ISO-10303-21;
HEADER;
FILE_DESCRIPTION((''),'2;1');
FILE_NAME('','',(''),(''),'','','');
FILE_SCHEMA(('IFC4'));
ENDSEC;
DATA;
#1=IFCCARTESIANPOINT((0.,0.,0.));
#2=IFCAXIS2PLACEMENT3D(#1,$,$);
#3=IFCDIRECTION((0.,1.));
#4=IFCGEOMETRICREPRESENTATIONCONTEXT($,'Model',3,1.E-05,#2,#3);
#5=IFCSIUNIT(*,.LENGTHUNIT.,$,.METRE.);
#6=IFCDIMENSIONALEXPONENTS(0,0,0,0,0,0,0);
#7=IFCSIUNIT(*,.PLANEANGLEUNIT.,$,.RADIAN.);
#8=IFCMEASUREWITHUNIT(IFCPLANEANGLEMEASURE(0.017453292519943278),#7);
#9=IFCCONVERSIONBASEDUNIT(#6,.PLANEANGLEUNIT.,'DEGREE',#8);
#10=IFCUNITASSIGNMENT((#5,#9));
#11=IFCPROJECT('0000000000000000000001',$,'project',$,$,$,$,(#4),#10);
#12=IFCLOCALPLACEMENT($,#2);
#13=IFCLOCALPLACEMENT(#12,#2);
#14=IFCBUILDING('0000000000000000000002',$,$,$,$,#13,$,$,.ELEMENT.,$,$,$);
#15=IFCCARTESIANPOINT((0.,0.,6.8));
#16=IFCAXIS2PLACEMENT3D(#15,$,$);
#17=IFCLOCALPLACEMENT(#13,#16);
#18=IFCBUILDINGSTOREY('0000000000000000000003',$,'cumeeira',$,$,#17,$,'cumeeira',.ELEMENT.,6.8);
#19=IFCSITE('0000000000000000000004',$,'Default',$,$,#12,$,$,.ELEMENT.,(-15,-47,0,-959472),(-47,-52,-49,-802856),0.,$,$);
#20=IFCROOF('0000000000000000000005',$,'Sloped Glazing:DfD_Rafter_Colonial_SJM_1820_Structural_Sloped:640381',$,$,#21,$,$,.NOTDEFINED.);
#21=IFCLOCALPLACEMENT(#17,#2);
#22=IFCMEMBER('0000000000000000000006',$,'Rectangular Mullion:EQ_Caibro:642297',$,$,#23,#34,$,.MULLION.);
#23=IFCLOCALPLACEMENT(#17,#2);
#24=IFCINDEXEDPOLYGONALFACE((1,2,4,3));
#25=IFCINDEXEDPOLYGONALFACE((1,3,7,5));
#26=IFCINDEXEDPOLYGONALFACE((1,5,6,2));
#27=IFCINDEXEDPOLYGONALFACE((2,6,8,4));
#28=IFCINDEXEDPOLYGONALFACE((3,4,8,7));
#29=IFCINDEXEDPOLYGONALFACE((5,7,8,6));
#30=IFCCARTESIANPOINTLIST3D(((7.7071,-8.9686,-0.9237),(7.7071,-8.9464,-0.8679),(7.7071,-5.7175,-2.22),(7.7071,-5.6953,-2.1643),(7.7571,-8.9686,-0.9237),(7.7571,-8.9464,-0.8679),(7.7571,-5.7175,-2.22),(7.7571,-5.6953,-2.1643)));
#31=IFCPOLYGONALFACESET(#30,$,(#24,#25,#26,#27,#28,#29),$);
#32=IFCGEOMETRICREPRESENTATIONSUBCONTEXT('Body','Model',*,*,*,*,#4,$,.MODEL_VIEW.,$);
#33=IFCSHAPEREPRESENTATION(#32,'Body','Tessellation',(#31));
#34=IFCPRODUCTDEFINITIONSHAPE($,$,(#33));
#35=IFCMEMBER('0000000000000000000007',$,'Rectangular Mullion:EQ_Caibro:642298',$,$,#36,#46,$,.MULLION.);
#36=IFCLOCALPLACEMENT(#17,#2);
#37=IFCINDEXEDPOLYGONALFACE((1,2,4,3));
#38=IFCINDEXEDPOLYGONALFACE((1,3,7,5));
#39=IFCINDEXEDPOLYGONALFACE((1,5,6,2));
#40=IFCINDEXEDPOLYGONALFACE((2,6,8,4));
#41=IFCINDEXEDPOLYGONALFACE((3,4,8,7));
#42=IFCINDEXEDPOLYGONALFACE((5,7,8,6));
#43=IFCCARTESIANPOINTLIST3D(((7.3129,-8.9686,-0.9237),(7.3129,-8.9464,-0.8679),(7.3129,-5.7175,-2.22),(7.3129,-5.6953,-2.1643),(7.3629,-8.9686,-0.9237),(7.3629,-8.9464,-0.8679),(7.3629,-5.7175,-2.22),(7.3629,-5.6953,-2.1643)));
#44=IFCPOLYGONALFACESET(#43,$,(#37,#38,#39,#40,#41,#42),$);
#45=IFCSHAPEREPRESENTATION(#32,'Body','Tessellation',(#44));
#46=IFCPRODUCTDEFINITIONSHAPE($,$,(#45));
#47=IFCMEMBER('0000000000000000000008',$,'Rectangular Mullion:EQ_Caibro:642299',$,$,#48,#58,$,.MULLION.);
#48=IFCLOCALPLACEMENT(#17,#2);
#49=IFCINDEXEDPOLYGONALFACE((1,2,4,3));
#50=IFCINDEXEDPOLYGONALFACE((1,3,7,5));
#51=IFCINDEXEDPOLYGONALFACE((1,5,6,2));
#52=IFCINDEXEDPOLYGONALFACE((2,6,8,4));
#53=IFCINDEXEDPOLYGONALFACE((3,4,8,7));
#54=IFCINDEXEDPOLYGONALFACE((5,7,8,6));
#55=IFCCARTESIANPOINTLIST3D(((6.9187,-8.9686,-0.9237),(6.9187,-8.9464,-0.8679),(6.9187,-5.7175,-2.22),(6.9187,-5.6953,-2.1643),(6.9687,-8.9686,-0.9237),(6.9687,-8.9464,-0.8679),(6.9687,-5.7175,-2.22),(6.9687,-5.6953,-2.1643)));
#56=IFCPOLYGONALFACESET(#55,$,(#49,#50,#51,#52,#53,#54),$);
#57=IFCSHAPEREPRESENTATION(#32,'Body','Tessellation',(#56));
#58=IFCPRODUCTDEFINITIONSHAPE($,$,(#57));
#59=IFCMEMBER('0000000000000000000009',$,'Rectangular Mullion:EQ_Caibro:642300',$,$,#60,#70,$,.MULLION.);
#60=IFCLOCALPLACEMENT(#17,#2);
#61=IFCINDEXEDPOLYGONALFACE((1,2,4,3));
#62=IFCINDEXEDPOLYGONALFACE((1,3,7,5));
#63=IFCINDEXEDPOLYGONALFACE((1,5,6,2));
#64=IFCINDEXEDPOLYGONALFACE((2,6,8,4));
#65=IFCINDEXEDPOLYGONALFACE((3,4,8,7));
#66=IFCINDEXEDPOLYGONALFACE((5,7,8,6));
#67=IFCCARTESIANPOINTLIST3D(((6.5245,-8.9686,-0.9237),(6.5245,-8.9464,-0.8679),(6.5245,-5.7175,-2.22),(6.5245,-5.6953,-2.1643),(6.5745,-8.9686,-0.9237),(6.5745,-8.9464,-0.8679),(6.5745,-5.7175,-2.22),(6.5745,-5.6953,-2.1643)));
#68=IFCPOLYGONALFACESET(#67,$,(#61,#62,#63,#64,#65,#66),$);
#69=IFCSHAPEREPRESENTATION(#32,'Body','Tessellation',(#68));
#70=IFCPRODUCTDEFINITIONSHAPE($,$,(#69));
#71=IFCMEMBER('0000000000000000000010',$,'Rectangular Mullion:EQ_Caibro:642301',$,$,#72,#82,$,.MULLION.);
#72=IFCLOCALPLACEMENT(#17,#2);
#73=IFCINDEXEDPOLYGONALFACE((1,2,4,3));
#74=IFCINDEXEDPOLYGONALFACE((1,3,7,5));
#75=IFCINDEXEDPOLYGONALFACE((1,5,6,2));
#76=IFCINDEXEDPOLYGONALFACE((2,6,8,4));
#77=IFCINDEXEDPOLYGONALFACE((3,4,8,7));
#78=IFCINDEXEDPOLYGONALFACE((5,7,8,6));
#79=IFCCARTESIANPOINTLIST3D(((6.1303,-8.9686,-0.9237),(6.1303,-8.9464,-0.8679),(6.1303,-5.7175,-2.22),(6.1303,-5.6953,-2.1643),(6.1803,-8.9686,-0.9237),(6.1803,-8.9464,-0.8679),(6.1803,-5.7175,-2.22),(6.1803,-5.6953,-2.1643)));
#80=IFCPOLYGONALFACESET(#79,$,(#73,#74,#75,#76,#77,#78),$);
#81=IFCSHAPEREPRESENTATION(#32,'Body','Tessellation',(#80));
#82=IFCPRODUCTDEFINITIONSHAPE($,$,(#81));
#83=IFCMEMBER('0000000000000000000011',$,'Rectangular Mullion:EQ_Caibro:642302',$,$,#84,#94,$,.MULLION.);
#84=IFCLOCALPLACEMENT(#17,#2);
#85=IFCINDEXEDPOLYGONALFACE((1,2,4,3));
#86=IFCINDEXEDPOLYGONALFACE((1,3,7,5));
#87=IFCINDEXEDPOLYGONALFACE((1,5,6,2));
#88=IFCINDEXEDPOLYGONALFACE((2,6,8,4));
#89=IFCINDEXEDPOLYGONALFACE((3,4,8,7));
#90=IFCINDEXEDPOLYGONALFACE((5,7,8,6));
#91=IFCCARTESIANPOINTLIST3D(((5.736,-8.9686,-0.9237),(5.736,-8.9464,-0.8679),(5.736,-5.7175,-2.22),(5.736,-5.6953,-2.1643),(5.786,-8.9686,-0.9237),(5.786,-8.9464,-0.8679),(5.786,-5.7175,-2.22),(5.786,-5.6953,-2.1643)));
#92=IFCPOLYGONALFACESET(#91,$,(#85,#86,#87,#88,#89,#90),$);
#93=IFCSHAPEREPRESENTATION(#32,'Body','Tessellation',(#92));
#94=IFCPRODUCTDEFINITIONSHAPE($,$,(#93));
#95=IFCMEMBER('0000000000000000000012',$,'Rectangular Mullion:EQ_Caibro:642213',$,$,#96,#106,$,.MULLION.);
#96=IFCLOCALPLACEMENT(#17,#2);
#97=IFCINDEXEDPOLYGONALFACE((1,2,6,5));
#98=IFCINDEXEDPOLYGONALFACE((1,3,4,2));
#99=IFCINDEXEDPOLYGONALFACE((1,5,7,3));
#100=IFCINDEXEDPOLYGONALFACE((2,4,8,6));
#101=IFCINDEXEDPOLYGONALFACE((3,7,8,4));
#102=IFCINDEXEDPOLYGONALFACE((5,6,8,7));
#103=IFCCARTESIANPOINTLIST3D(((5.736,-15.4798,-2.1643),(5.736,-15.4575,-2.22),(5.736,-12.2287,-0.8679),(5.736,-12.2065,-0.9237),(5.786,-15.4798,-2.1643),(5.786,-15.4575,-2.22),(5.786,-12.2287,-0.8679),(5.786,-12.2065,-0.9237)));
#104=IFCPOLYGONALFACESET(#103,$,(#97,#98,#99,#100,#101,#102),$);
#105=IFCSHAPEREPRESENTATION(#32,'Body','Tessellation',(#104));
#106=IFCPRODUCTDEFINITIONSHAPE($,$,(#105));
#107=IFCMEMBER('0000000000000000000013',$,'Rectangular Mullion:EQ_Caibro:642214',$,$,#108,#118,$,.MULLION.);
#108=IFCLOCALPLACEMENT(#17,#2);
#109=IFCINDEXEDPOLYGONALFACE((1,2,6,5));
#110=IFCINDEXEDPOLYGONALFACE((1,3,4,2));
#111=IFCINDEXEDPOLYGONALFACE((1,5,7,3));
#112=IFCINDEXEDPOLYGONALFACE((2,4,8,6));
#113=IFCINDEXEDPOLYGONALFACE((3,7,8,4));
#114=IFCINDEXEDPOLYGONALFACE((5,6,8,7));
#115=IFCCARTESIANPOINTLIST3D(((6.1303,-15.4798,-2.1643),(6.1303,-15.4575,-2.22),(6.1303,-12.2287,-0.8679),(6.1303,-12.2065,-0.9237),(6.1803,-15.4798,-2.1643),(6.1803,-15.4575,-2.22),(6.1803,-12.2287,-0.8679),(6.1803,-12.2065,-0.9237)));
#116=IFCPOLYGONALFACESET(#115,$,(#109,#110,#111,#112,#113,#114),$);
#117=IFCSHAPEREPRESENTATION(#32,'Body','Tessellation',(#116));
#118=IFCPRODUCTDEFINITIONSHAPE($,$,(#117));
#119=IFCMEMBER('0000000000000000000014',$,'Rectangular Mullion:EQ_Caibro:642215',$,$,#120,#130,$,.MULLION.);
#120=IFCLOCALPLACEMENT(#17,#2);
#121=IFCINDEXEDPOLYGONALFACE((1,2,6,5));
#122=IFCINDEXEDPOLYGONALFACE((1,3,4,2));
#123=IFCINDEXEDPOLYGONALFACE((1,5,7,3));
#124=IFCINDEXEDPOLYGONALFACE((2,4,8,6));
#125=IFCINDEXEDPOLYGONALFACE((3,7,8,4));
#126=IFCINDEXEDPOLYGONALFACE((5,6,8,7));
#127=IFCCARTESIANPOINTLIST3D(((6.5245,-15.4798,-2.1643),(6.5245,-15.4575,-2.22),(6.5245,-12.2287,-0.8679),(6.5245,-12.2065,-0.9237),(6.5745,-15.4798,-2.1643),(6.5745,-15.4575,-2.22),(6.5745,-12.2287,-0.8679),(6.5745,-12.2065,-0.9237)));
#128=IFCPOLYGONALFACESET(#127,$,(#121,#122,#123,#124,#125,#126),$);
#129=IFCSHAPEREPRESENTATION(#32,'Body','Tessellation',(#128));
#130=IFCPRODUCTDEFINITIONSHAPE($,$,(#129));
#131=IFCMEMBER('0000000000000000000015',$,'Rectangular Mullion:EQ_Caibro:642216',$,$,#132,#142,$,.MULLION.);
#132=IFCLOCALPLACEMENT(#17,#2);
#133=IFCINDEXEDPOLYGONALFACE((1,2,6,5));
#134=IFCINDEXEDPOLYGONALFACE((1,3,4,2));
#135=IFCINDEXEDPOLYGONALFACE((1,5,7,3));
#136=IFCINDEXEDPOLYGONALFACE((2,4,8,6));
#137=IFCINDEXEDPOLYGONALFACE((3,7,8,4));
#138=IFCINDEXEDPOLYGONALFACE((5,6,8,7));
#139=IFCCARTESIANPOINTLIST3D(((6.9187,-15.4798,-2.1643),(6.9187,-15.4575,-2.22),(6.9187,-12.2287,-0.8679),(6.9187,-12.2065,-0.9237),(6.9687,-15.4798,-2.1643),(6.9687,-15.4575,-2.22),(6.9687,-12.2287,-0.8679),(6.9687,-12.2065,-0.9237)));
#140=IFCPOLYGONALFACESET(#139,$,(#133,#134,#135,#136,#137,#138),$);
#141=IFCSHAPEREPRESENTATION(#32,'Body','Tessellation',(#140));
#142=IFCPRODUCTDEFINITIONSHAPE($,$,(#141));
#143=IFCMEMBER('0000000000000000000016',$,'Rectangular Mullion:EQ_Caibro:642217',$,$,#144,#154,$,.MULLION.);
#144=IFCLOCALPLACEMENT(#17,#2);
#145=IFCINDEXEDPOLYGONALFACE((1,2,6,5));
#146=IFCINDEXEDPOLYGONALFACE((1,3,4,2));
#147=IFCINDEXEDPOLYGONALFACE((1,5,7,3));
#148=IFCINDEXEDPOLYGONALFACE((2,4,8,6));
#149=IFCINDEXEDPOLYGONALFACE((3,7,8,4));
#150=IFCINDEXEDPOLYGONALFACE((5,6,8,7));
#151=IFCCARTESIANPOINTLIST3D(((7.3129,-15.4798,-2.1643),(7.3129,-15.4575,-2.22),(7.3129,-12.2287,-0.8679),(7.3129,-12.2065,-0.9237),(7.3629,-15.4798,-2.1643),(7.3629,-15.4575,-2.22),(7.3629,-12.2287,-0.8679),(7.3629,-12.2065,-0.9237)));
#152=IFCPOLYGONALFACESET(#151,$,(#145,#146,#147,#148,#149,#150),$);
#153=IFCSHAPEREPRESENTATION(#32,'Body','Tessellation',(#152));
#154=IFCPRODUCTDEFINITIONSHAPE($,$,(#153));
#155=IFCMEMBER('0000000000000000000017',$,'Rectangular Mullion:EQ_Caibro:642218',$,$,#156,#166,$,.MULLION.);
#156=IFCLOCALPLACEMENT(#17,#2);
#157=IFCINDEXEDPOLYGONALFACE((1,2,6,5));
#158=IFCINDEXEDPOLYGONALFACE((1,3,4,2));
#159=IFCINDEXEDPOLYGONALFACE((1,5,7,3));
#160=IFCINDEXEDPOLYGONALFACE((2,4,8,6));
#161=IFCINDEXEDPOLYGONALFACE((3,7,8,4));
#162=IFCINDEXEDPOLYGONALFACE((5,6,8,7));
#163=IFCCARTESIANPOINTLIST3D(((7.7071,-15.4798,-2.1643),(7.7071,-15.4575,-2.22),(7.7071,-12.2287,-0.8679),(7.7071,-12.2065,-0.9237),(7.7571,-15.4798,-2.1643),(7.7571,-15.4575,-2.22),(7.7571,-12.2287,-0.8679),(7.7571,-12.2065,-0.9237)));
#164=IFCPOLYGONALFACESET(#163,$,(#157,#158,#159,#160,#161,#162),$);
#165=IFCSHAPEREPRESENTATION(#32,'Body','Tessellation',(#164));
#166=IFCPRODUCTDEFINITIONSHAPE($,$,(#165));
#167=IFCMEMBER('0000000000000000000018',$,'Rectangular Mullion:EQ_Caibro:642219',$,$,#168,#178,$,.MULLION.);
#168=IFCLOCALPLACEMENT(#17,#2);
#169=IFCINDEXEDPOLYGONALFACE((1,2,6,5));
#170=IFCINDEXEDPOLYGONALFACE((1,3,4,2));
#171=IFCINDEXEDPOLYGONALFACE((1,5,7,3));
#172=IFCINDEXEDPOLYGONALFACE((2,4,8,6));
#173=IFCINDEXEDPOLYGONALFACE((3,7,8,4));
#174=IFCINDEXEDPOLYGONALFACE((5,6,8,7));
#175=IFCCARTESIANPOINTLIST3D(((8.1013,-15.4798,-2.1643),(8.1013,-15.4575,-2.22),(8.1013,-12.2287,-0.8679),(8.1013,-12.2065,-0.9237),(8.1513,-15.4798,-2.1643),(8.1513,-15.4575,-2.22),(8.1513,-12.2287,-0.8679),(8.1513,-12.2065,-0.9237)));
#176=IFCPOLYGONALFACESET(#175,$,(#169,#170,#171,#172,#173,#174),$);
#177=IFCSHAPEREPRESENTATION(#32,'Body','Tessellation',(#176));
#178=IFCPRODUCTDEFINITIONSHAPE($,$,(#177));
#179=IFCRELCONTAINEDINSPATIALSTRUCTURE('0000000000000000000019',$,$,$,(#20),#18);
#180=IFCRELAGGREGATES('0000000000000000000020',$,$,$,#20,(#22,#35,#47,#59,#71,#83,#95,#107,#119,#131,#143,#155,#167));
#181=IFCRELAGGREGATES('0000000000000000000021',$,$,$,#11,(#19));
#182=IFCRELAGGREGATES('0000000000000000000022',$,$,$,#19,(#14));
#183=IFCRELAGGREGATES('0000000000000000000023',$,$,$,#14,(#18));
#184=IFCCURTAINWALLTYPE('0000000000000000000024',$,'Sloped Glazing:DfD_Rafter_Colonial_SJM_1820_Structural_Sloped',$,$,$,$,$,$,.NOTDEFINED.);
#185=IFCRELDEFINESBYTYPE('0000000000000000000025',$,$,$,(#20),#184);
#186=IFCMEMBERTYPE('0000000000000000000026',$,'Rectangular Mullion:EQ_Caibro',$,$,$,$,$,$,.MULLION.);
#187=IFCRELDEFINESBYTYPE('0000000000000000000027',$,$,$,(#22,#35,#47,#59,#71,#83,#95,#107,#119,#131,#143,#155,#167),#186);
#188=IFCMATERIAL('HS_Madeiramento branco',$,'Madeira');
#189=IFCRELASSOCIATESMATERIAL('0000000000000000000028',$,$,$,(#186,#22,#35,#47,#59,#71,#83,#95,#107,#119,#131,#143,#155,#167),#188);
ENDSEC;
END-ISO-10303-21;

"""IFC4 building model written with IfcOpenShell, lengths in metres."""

from ifc_helpers import new_model, entity, si_unit, converted_unit, direction, frame, origin, place, context, subcontext, project, spatial, indexed_curve, outline, extrude, source, transform, mapped, material, type_object, type_shapes, element, aggregate, save


model = new_model("IFC4")

# Units and contexts
model_context = context("Model", 3, precision=1e-05, world=origin(), true_north=direction((0.0, 1.0)))
body_context = subcontext(model_context, "Body", "Model", "MODEL_VIEW")
ifc_project = project(units=[si_unit("LENGTHUNIT", "METRE"), converted_unit("PLANEANGLEUNIT", "DEGREE", entity("IfcPlaneAngleMeasure", 0.017453292519943278), si_unit("PLANEANGLEUNIT", "RADIAN"), dimensions=[0, 0, 0, 0, 0, 0, 0])], contexts=[model_context])

# Site, building, storey
site_placement = place(None, origin())
site = spatial("IfcSite", under=ifc_project, at=site_placement, Name="Default", CompositionType="ELEMENT", RefLatitude=(-15, -47, 0, -959472), RefLongitude=(-47, -52, -49, -802856), RefElevation=0.0)
building_placement = place(site_placement, origin())
building = spatial("IfcBuilding", under=site, at=building_placement, CompositionType="ELEMENT")
storey_placement = place(building_placement, frame((0.0, 0.0, 6.8)))
storey = spatial("IfcBuildingStorey", under=building, at=storey_placement, Name="cumeeira", LongName="cumeeira", CompositionType="ELEMENT", Elevation=6.8)

# Roof, members
curtain_wall_type = type_object("IfcCurtainWallType", Name="Sloped Glazing:DfD_Rafter_Colonial_SJM_1820_Structural_Sloped", PredefinedType="NOTDEFINED")
roof_placement = place(storey_placement, frame((0.0, 0.0, -6.8)))
roof = element("IfcRoof", 1, at=roof_placement, inside=storey, type_object=curtain_wall_type, Name="Sloped Glazing:DfD_Rafter_Colonial_SJM_1820_Structural_Sloped:640381", PredefinedType="NOTDEFINED")
ifc_material = material(Name="HS_Madeiramento branco", Category="Madeira")
member_type_1 = type_object("IfcMemberType", Name="Rectangular Mullion:EQ_Caibro", PredefinedType="MULLION", material=ifc_material)
shared_shape_1 = source(origin(), body_context, "Body", "SweptSolid", [
    extrude(outline(indexed_curve([(-0.025, -0.03), (0.025, -0.03), (0.025, 0.03), (-0.025, 0.03), (-0.025, -0.03)], self_intersect=False)), frame((0.0, -0.03, -3.5), z_axis=(0.0, 0.0, 1.0), x_axis=(-1.0, 0.0, 0.0)), (0.0, 0.0, 1.0), 3.5),
])
type_shapes(member_type_1, [shared_shape_1])
member_1_placement = place(roof_placement, frame((7.7321, -8.9686, 5.8763), z_axis=(0.0, -0.928878, 0.370385), x_axis=(-1.0, 0.0, 0.0)))
member_1 = element("IfcMember", 2, at=member_1_placement, type_object=member_type_1, material=ifc_material, Name="Rectangular Mullion:EQ_Caibro:642297", PredefinedType="MULLION", context=body_context, shape_type="MappedRepresentation", body=[
    mapped(shared_shape_1, transform((0.0, 0.0, 0.0), scale=1.0)),
])
member_2_placement = place(roof_placement, frame((7.3379, -8.9686, 5.8763), z_axis=(0.0, -0.928878, 0.370385), x_axis=(-1.0, 0.0, 0.0)))
member_2 = element("IfcMember", 3, at=member_2_placement, type_object=member_type_1, material=ifc_material, Name="Rectangular Mullion:EQ_Caibro:642298", PredefinedType="MULLION", context=body_context, shape_type="MappedRepresentation", body=[
    mapped(shared_shape_1, transform((0.0, 0.0, 0.0), scale=1.0)),
])
member_3_placement = place(roof_placement, frame((6.9437, -8.9686, 5.8763), z_axis=(0.0, -0.928878, 0.370385), x_axis=(-1.0, 0.0, 0.0)))
member_3 = element("IfcMember", 4, at=member_3_placement, type_object=member_type_1, material=ifc_material, Name="Rectangular Mullion:EQ_Caibro:642299", PredefinedType="MULLION", context=body_context, shape_type="MappedRepresentation", body=[
    mapped(shared_shape_1, transform((0.0, 0.0, 0.0), scale=1.0)),
])
member_4_placement = place(roof_placement, frame((6.5495, -8.9686, 5.8763), z_axis=(0.0, -0.928878, 0.370385), x_axis=(-1.0, 0.0, 0.0)))
member_4 = element("IfcMember", 5, at=member_4_placement, type_object=member_type_1, material=ifc_material, Name="Rectangular Mullion:EQ_Caibro:642300", PredefinedType="MULLION", context=body_context, shape_type="MappedRepresentation", body=[
    mapped(shared_shape_1, transform((0.0, 0.0, 0.0), scale=1.0)),
])
member_5_placement = place(roof_placement, frame((6.1553, -8.9686, 5.8763), z_axis=(0.0, -0.928878, 0.370385), x_axis=(-1.0, 0.0, 0.0)))
member_5 = element("IfcMember", 6, at=member_5_placement, type_object=member_type_1, material=ifc_material, Name="Rectangular Mullion:EQ_Caibro:642301", PredefinedType="MULLION", context=body_context, shape_type="MappedRepresentation", body=[
    mapped(shared_shape_1, transform((0.0, 0.0, 0.0), scale=1.0)),
])
member_6_placement = place(roof_placement, frame((5.761, -8.9686, 5.8763), z_axis=(0.0, -0.928878, 0.370385), x_axis=(-1.0, 0.0, 0.0)))
member_6 = element("IfcMember", 7, at=member_6_placement, type_object=member_type_1, material=ifc_material, Name="Rectangular Mullion:EQ_Caibro:642302", PredefinedType="MULLION", context=body_context, shape_type="MappedRepresentation", body=[
    mapped(shared_shape_1, transform((0.0, 0.0, 0.0), scale=1.0)),
])
member_7_placement = place(roof_placement, frame((5.761, -12.2065, 5.8763), z_axis=(0.0, 0.928878, 0.370385), x_axis=(1.0, 0.0, 0.0)))
member_7 = element("IfcMember", 8, at=member_7_placement, type_object=member_type_1, material=ifc_material, Name="Rectangular Mullion:EQ_Caibro:642213", PredefinedType="MULLION", context=body_context, shape_type="MappedRepresentation", body=[
    mapped(shared_shape_1, transform((0.0, 0.0, 0.0), scale=1.0)),
])
member_8_placement = place(roof_placement, frame((6.1553, -12.2065, 5.8763), z_axis=(0.0, 0.928878, 0.370385), x_axis=(1.0, 0.0, 0.0)))
member_8 = element("IfcMember", 9, at=member_8_placement, type_object=member_type_1, material=ifc_material, Name="Rectangular Mullion:EQ_Caibro:642214", PredefinedType="MULLION", context=body_context, shape_type="MappedRepresentation", body=[
    mapped(shared_shape_1, transform((0.0, 0.0, 0.0), scale=1.0)),
])
member_9_placement = place(roof_placement, frame((6.5495, -12.2065, 5.8763), z_axis=(0.0, 0.928878, 0.370385), x_axis=(1.0, 0.0, 0.0)))
member_9 = element("IfcMember", 10, at=member_9_placement, type_object=member_type_1, material=ifc_material, Name="Rectangular Mullion:EQ_Caibro:642215", PredefinedType="MULLION", context=body_context, shape_type="MappedRepresentation", body=[
    mapped(shared_shape_1, transform((0.0, 0.0, 0.0), scale=1.0)),
])
member_10_placement = place(roof_placement, frame((6.9437, -12.2065, 5.8763), z_axis=(0.0, 0.928878, 0.370385), x_axis=(1.0, 0.0, 0.0)))
member_10 = element("IfcMember", 11, at=member_10_placement, type_object=member_type_1, material=ifc_material, Name="Rectangular Mullion:EQ_Caibro:642216", PredefinedType="MULLION", context=body_context, shape_type="MappedRepresentation", body=[
    mapped(shared_shape_1, transform((0.0, 0.0, 0.0), scale=1.0)),
])
member_11_placement = place(roof_placement, frame((7.3379, -12.2065, 5.8763), z_axis=(0.0, 0.928878, 0.370385), x_axis=(1.0, 0.0, 0.0)))
member_11 = element("IfcMember", 12, at=member_11_placement, type_object=member_type_1, material=ifc_material, Name="Rectangular Mullion:EQ_Caibro:642217", PredefinedType="MULLION", context=body_context, shape_type="MappedRepresentation", body=[
    mapped(shared_shape_1, transform((0.0, 0.0, 0.0), scale=1.0)),
])
member_12_placement = place(roof_placement, frame((7.7321, -12.2065, 5.8763), z_axis=(0.0, 0.928878, 0.370385), x_axis=(1.0, 0.0, 0.0)))
member_12 = element("IfcMember", 13, at=member_12_placement, type_object=member_type_1, material=ifc_material, Name="Rectangular Mullion:EQ_Caibro:642218", PredefinedType="MULLION", context=body_context, shape_type="MappedRepresentation", body=[
    mapped(shared_shape_1, transform((0.0, 0.0, 0.0), scale=1.0)),
])
member_13_placement = place(roof_placement, frame((8.1263, -12.2065, 5.8763), z_axis=(0.0, 0.928878, 0.370385), x_axis=(1.0, 0.0, 0.0)))
member_13 = element("IfcMember", 14, at=member_13_placement, type_object=member_type_1, material=ifc_material, Name="Rectangular Mullion:EQ_Caibro:642219", PredefinedType="MULLION", context=body_context, shape_type="MappedRepresentation", body=[
    mapped(shared_shape_1, transform((0.0, 0.0, 0.0), scale=1.0)),
])
aggregate(roof, [member_1, member_2, member_3, member_4, member_5, member_6, member_7, member_8, member_9, member_10, member_11, member_12, member_13])

save(model, "model.ifc")
